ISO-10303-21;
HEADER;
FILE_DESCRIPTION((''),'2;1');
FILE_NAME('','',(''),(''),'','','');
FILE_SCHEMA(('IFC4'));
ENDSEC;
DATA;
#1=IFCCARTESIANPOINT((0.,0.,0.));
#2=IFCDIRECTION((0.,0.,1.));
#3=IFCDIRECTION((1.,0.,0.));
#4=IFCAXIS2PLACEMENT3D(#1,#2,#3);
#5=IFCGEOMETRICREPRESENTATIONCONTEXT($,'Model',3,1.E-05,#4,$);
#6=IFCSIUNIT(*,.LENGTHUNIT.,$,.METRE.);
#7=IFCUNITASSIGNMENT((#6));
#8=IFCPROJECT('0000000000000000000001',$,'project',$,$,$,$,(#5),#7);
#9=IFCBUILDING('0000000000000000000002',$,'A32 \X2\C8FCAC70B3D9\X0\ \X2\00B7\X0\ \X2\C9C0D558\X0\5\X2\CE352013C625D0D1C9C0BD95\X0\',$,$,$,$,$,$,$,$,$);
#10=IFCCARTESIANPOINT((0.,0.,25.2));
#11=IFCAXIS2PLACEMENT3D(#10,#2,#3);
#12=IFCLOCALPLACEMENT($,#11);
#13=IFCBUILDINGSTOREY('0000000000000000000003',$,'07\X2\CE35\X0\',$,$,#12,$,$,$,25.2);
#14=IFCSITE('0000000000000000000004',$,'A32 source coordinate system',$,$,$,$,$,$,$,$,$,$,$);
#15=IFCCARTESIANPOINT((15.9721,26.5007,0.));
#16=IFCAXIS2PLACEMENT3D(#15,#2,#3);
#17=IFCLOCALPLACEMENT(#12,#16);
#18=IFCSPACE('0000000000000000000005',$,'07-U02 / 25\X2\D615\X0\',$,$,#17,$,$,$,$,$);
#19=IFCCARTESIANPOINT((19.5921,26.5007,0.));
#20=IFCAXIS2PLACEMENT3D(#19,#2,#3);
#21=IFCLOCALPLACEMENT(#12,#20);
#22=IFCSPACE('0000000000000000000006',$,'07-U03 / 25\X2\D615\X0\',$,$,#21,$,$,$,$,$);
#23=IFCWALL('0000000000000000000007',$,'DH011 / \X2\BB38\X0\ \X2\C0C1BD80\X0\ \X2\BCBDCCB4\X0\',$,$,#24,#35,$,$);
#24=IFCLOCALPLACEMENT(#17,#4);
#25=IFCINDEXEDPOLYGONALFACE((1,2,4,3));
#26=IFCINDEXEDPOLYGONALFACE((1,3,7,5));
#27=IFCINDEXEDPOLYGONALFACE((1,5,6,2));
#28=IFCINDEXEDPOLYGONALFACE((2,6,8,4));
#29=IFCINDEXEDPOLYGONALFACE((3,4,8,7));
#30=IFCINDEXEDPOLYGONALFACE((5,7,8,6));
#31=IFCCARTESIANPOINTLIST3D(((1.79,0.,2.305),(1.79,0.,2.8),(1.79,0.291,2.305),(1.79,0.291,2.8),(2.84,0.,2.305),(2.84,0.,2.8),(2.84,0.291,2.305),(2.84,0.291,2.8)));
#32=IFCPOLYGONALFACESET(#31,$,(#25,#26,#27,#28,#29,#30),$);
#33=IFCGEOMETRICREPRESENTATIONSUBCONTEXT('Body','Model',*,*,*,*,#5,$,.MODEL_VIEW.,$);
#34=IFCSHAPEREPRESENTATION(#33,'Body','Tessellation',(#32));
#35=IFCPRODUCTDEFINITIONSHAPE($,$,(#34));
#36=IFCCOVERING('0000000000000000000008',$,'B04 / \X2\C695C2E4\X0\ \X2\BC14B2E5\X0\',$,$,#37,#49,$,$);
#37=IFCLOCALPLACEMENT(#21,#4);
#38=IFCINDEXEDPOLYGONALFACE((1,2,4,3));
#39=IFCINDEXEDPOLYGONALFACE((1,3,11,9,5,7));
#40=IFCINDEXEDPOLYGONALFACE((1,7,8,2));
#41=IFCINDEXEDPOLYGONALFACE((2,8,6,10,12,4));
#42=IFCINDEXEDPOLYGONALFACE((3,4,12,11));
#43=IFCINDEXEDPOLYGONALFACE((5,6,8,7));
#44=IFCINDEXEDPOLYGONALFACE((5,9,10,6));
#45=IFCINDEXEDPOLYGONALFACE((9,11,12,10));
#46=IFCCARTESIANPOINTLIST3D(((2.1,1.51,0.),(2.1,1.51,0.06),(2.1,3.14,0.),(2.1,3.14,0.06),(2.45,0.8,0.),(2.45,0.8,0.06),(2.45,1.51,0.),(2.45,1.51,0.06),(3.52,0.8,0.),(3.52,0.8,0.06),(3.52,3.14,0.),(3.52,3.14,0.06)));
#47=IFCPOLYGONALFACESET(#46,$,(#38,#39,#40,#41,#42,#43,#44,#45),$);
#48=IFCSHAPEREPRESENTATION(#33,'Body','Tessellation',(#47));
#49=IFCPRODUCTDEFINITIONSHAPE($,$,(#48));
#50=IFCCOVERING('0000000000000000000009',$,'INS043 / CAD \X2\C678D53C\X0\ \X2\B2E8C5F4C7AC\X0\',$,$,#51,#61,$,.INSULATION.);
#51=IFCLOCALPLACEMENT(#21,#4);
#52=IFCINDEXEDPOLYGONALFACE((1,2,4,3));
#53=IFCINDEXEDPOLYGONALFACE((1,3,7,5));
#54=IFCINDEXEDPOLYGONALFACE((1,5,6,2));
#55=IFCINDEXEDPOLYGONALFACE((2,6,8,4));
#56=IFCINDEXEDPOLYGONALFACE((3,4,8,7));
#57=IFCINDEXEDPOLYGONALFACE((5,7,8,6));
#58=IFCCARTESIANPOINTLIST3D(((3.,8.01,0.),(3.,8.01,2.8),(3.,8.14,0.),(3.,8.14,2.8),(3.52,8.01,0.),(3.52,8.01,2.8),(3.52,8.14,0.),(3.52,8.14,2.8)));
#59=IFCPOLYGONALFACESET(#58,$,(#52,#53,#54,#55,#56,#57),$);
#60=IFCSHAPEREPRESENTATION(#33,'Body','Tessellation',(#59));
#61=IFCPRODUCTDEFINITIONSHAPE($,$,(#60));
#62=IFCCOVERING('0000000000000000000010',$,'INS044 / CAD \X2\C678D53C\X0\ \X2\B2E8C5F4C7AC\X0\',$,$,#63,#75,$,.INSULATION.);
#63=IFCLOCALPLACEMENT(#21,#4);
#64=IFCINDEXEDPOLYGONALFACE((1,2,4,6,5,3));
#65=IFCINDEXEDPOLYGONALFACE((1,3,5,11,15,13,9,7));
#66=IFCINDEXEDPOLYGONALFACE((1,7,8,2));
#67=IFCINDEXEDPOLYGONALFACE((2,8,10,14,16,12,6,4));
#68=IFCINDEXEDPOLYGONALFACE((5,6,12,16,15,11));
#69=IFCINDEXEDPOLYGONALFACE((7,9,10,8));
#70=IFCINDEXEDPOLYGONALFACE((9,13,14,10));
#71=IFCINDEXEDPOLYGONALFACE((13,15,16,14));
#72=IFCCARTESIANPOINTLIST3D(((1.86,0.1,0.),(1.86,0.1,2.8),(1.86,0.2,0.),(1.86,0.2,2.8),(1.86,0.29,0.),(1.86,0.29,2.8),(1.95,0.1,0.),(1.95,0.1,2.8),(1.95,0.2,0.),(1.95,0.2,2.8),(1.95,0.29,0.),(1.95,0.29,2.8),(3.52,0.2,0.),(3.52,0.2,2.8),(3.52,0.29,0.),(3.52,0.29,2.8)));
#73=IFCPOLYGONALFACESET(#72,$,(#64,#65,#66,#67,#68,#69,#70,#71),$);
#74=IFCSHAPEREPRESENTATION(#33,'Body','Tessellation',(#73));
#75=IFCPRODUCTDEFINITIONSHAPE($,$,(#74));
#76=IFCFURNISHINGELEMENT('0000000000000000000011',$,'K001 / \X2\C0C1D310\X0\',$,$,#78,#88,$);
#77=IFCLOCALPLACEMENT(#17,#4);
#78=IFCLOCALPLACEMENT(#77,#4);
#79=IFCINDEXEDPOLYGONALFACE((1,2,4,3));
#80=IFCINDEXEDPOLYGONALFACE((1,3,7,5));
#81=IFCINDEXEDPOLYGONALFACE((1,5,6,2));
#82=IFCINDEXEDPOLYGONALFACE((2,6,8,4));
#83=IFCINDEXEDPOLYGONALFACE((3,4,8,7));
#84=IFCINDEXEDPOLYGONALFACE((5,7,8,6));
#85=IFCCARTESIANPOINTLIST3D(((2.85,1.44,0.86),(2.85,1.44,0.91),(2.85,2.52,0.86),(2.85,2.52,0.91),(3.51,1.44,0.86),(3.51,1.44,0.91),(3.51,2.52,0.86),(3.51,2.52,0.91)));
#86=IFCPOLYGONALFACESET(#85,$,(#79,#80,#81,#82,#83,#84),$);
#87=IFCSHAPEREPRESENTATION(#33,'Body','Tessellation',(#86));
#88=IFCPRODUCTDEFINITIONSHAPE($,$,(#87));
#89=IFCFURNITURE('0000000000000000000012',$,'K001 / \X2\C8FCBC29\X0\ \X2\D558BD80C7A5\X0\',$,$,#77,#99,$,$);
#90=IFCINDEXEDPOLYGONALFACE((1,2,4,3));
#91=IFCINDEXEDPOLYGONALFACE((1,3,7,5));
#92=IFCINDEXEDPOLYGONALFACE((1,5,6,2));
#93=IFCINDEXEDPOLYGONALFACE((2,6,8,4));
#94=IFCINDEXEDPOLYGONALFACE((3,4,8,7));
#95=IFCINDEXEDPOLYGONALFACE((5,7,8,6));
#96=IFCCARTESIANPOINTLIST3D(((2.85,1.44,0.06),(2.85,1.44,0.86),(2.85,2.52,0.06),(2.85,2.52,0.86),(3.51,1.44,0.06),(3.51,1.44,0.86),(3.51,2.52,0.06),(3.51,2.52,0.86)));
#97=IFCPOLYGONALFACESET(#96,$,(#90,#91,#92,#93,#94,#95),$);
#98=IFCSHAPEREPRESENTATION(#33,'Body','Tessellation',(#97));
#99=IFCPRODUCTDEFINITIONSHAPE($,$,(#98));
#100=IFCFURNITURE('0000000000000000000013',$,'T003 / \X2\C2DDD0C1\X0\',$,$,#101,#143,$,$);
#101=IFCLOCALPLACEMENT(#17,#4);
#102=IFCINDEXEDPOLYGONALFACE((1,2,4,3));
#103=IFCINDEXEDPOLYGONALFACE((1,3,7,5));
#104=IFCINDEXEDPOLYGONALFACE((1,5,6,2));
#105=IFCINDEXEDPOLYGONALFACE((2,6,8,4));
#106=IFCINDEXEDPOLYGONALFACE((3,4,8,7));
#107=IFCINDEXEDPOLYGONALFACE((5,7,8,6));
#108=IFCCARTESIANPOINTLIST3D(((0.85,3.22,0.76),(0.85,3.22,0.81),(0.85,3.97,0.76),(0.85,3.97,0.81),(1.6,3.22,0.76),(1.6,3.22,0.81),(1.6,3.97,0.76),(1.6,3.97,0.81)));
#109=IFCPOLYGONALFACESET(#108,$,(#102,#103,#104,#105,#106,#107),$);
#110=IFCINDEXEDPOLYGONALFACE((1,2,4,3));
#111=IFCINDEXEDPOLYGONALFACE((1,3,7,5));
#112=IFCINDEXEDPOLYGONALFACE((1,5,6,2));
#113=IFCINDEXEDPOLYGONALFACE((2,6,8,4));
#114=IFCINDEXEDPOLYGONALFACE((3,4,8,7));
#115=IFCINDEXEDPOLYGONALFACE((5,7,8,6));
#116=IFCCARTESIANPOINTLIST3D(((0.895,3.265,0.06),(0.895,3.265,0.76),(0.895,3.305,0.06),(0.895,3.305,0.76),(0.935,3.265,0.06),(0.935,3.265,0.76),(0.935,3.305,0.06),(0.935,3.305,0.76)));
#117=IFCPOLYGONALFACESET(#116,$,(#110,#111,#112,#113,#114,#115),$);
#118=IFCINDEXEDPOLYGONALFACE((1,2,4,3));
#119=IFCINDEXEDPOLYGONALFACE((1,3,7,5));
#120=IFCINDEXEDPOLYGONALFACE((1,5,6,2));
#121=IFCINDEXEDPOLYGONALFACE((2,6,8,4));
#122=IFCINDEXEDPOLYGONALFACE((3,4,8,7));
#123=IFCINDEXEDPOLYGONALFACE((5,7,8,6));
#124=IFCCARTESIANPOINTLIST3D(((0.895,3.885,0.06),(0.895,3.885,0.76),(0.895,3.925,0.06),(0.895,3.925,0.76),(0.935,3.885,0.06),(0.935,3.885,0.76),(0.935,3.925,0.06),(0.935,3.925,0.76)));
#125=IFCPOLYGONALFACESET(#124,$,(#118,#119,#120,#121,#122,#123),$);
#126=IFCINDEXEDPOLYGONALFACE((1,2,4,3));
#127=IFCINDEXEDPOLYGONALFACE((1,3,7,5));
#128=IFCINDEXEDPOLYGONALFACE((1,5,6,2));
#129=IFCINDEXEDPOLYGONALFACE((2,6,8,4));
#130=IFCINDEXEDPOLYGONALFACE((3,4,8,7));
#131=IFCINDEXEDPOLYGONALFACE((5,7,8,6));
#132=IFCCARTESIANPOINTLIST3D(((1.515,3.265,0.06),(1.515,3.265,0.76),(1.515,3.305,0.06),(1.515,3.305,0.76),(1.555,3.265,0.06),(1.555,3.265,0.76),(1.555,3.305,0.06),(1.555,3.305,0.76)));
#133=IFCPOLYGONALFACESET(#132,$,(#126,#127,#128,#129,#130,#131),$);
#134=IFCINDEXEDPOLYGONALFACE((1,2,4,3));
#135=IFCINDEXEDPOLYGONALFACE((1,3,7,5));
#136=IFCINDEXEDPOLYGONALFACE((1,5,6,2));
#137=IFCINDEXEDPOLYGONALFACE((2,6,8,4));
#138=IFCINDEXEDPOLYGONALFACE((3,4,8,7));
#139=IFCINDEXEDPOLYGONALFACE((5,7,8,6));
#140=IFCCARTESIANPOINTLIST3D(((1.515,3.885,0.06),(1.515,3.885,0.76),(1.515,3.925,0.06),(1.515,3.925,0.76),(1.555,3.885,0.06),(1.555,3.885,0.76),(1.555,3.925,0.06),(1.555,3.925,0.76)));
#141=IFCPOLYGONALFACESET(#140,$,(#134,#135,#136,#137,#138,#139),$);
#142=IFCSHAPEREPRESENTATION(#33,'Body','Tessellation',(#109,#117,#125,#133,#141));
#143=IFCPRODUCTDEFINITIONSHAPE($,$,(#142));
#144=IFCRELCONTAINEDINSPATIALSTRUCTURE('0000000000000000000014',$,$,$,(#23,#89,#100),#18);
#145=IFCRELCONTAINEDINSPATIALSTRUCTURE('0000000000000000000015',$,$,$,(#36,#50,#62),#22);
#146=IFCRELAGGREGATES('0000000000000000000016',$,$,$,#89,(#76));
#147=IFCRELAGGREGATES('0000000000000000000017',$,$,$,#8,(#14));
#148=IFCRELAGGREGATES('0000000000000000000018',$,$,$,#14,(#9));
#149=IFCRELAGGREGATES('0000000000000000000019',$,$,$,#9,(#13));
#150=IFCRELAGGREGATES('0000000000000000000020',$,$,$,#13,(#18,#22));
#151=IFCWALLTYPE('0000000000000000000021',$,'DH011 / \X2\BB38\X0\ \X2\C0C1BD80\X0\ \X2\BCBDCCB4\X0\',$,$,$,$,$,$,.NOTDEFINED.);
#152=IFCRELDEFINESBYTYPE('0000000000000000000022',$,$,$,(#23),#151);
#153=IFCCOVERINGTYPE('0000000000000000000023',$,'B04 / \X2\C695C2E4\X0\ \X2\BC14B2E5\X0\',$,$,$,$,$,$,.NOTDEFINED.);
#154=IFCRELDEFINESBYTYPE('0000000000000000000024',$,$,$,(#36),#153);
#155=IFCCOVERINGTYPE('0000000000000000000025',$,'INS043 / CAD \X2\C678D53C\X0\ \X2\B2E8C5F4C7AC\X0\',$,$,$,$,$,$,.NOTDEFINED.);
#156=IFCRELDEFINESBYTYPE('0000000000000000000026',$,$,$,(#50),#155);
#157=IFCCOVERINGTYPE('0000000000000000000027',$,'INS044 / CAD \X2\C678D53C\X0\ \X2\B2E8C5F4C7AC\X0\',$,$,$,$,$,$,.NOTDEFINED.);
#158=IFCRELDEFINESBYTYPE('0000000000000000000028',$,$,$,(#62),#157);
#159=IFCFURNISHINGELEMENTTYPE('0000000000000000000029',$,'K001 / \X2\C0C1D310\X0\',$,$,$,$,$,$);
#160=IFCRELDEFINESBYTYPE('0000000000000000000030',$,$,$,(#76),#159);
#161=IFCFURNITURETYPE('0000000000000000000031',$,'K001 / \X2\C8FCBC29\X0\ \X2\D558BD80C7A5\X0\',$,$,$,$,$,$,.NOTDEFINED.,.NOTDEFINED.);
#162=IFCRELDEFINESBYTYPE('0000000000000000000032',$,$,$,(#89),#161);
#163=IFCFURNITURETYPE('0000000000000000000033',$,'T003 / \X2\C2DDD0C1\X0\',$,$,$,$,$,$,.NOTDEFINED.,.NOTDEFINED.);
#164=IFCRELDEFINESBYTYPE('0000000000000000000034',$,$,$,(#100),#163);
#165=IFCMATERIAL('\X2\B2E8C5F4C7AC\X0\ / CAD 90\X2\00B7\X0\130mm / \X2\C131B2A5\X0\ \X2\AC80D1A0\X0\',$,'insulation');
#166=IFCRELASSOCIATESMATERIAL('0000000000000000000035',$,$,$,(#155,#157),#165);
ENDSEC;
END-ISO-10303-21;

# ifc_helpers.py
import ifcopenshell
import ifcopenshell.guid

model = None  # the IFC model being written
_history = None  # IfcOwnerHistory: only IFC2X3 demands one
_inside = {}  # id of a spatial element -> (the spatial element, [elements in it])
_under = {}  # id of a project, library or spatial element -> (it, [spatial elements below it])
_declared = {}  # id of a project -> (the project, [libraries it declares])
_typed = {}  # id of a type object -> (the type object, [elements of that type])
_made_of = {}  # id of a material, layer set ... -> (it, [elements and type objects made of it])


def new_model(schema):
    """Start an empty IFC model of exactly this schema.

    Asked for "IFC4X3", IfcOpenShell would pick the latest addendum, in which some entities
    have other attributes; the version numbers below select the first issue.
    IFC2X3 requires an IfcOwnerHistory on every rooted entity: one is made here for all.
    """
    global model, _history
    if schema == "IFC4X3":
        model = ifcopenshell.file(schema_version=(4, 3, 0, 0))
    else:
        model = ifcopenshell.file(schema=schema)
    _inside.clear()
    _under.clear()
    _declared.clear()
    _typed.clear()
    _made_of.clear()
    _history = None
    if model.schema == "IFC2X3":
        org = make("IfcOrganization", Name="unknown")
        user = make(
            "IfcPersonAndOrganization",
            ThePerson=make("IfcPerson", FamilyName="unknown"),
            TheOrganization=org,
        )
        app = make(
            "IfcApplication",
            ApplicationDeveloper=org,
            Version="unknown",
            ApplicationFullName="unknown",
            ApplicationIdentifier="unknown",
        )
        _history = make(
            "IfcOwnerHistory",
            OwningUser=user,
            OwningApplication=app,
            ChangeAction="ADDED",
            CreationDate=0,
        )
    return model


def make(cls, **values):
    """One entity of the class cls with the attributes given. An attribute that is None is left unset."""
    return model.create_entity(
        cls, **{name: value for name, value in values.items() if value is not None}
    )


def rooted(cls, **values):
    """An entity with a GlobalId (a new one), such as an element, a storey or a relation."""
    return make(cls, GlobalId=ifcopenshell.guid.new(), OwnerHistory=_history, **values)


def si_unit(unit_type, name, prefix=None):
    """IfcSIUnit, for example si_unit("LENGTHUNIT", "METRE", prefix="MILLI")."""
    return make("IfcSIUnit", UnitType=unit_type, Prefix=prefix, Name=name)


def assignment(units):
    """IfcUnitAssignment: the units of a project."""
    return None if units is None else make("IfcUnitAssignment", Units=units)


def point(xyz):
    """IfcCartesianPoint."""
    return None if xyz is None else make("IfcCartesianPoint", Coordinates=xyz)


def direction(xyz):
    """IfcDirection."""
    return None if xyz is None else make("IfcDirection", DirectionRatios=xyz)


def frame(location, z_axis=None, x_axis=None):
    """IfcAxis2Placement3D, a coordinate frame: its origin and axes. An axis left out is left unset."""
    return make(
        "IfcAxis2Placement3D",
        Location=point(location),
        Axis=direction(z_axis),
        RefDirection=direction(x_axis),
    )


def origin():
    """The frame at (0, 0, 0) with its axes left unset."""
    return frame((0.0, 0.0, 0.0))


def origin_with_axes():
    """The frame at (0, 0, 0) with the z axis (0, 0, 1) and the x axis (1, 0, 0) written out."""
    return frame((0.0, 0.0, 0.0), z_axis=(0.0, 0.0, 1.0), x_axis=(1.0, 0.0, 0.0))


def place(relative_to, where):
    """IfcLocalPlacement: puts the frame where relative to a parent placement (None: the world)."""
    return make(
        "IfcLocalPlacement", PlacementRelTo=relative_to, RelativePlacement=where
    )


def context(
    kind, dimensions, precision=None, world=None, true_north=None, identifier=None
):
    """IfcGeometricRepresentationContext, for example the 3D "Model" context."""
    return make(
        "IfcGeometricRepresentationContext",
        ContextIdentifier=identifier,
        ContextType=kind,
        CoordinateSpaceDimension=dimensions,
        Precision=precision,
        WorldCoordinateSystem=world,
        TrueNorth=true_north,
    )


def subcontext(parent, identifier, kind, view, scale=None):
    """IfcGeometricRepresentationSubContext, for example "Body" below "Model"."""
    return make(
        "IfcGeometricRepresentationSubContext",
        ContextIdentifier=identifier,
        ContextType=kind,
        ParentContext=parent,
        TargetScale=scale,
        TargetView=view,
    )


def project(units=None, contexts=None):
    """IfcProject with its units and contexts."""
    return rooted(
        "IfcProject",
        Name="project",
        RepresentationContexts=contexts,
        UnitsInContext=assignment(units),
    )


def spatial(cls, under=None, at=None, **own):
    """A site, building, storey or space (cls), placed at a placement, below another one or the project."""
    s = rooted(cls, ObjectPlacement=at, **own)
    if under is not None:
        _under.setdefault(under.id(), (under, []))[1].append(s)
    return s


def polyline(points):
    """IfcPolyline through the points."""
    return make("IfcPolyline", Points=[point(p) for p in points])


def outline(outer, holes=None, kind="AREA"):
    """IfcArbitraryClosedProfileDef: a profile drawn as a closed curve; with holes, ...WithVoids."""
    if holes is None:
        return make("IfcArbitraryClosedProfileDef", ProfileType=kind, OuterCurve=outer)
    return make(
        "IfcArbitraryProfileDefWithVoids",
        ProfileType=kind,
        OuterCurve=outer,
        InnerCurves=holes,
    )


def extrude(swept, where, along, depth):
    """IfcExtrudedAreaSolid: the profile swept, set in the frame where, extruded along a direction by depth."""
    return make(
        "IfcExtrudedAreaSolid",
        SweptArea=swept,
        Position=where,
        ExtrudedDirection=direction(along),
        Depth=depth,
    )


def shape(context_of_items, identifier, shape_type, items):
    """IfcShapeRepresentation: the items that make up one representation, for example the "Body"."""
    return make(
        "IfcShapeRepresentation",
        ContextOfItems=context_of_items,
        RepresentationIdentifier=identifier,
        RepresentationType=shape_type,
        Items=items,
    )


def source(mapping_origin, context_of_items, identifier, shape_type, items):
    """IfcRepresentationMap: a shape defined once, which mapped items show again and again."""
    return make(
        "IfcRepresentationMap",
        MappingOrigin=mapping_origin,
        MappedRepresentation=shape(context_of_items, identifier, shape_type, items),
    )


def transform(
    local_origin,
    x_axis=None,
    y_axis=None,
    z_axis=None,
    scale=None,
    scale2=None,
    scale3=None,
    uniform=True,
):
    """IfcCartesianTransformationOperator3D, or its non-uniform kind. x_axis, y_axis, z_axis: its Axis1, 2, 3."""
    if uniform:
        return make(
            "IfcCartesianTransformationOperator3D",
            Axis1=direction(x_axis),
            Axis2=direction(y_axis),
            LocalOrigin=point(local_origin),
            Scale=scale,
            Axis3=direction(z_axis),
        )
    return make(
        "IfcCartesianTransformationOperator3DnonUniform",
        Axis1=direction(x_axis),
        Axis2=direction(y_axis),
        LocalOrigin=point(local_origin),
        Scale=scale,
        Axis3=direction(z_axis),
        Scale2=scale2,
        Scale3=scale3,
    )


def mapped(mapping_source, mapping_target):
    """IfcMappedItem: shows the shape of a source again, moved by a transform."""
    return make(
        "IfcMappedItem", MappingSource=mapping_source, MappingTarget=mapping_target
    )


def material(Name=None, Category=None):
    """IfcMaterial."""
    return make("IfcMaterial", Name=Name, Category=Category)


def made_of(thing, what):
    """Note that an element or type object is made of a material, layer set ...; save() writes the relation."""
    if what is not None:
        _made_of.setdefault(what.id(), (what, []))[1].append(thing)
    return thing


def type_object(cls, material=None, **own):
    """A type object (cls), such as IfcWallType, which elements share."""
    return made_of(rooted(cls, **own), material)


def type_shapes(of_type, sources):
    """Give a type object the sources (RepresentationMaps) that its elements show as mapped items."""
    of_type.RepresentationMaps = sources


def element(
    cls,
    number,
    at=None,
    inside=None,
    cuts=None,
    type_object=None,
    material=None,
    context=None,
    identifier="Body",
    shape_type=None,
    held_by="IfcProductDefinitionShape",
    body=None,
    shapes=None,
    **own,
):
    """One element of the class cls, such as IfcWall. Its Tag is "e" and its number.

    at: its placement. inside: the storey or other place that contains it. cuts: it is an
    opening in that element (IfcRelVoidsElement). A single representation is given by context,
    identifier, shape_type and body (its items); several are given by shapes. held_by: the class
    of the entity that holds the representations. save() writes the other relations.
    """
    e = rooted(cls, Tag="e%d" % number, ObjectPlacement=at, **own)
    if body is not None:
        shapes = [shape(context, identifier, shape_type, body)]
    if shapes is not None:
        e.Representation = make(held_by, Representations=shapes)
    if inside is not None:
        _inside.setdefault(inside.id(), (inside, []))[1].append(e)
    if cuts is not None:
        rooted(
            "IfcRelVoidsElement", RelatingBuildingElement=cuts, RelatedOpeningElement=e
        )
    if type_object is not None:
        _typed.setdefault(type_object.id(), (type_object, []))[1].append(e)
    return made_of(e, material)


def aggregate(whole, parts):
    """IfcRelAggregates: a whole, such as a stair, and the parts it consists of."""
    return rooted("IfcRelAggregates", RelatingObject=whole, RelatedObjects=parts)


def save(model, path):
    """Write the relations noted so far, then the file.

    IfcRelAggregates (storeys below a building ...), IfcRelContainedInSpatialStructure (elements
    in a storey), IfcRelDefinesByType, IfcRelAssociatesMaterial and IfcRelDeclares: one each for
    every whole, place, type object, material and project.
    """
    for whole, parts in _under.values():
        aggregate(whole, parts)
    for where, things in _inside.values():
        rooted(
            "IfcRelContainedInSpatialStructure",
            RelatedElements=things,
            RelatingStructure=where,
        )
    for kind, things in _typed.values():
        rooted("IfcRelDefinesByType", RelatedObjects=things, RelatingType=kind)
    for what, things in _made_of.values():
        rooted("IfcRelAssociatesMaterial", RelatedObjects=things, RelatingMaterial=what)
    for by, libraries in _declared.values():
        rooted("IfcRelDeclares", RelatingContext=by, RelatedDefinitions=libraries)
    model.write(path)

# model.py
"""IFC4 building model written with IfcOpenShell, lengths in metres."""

from ifc_helpers import new_model, si_unit, frame, origin, origin_with_axes, place, context, subcontext, project, spatial, polyline, outline, extrude, source, transform, mapped, material, type_object, type_shapes, element, aggregate, save


model = new_model("IFC4")

# Units and contexts
model_context = context("Model", 3, precision=1e-05, world=origin_with_axes())
body_context = subcontext(model_context, "Body", "Model", "MODEL_VIEW")
ifc_project = project(units=[si_unit("LENGTHUNIT", "METRE")], contexts=[model_context])

# Site, building, storey, space
site = spatial("IfcSite", under=ifc_project, Name="A32 source coordinate system")
building = spatial("IfcBuilding", under=site, Name="A32 주거동 · 지하5층–옥탑지붕")
storey_placement = place(None, frame((0.0, 0.0, 25.2), z_axis=(0.0, 0.0, 1.0), x_axis=(1.0, 0.0, 0.0)))
storey = spatial("IfcBuildingStorey", under=building, at=storey_placement, Name="07층", Elevation=25.2)
space_1_placement = place(storey_placement, frame((15.9721, 26.5007, 0.0), z_axis=(0.0, 0.0, 1.0), x_axis=(1.0, 0.0, 0.0)))
space_1 = spatial("IfcSpace", under=storey, at=space_1_placement, Name="07-U02 / 25형")

# Wall
wall_type_1 = type_object("IfcWallType", Name="DH011 / 문 상부 벽체", PredefinedType="NOTDEFINED")
shared_shape_1 = source(origin(), body_context, "Body", "SweptSolid", [
    extrude(outline(polyline([(2.84, 0.0), (1.79, 0.0), (1.79, 0.291), (2.84, 0.291), (2.84, 0.0)])), frame((0.0, 0.0, 2.305)), (0.0, 0.0, 1.0), 0.495),
])
type_shapes(wall_type_1, [shared_shape_1])
wall_1_placement = place(space_1_placement, origin_with_axes())
element("IfcWall", 1, at=wall_1_placement, inside=space_1, type_object=wall_type_1, Name="DH011 / 문 상부 벽체", context=body_context, shape_type="MappedRepresentation", body=[
    mapped(shared_shape_1, transform((0.0, 0.0, 0.0), scale=1.0)),
])

# Shared definitions
space_2_placement = place(storey_placement, frame((19.5921, 26.5007, 0.0), z_axis=(0.0, 0.0, 1.0), x_axis=(1.0, 0.0, 0.0)))
space_2 = spatial("IfcSpace", under=storey, at=space_2_placement, Name="07-U03 / 25형")

# Coverings
covering_type_1 = type_object("IfcCoveringType", Name="B04 / 욕실 바닥", PredefinedType="NOTDEFINED")
shared_shape_2 = source(origin(), body_context, "Body", "SweptSolid", [
    extrude(outline(polyline([(2.1, 1.51), (2.1, 3.14), (3.52, 3.14), (3.52, 0.8), (2.45, 0.8), (2.45, 1.51), (2.1, 1.51)])), origin(), (0.0, 0.0, 1.0), 0.06),
])
type_shapes(covering_type_1, [shared_shape_2])
covering_1_placement = place(space_2_placement, origin_with_axes())
element("IfcCovering", 2, at=covering_1_placement, inside=space_2, type_object=covering_type_1, Name="B04 / 욕실 바닥", context=body_context, shape_type="MappedRepresentation", body=[
    mapped(shared_shape_2, transform((0.0, 0.0, 0.0), scale=1.0)),
])
ifc_material = material(Name="단열재 / CAD 90·130mm / 성능 검토", Category="insulation")
covering_type_2 = type_object("IfcCoveringType", Name="INS043 / CAD 외피 단열재", PredefinedType="NOTDEFINED", material=ifc_material)
shared_shape_3 = source(origin(), body_context, "Body", "SweptSolid", [
    extrude(outline(polyline([(3.52, 8.14), (3.52, 8.01), (3.0, 8.01), (3.0, 8.14), (3.52, 8.14)])), origin(), (0.0, 0.0, 1.0), 2.8),
])
type_shapes(covering_type_2, [shared_shape_3])
covering_2_placement = place(space_2_placement, origin_with_axes())
element("IfcCovering", 3, at=covering_2_placement, inside=space_2, type_object=covering_type_2, Name="INS043 / CAD 외피 단열재", PredefinedType="INSULATION", context=body_context, shape_type="MappedRepresentation", body=[
    mapped(shared_shape_3, transform((0.0, 0.0, 0.0), scale=1.0)),
])
covering_type_3 = type_object("IfcCoveringType", Name="INS044 / CAD 외피 단열재", PredefinedType="NOTDEFINED", material=ifc_material)
shared_shape_4 = source(origin(), body_context, "Body", "SweptSolid", [
    extrude(outline(polyline([(1.86, 0.2), (1.86, 0.29), (1.95, 0.29), (3.52, 0.29), (3.52, 0.2), (1.95, 0.2), (1.95, 0.1), (1.86, 0.1), (1.86, 0.2)])), origin(), (0.0, 0.0, 1.0), 2.8),
])
type_shapes(covering_type_3, [shared_shape_4])
covering_3_placement = place(space_2_placement, origin_with_axes())
element("IfcCovering", 4, at=covering_3_placement, inside=space_2, type_object=covering_type_3, Name="INS044 / CAD 외피 단열재", PredefinedType="INSULATION", context=body_context, shape_type="MappedRepresentation", body=[
    mapped(shared_shape_4, transform((0.0, 0.0, 0.0), scale=1.0)),
])

# Furnishing element
furnishing_element_type_1 = type_object("IfcFurnishingElementType", Name="K001 / 상판")
shared_shape_5 = source(origin(), body_context, "Body", "SweptSolid", [
    extrude(outline(polyline([(2.85, 2.52), (3.51, 2.52), (3.51, 1.44), (2.85, 1.44), (2.85, 2.52)])), frame((0.0, 0.0, 0.86)), (0.0, 0.0, 1.0), 0.05),
])
type_shapes(furnishing_element_type_1, [shared_shape_5])
furniture_1_placement = place(space_1_placement, origin_with_axes())
furnishing_1_placement = place(furniture_1_placement, origin_with_axes())
furnishing_1 = element("IfcFurnishingElement", 5, at=furnishing_1_placement, type_object=furnishing_element_type_1, Name="K001 / 상판", context=body_context, shape_type="MappedRepresentation", body=[
    mapped(shared_shape_5, transform((0.0, 0.0, 0.0), scale=1.0)),
])

# Furniture
furniture_type_1 = type_object("IfcFurnitureType", Name="K001 / 주방 하부장", AssemblyPlace="NOTDEFINED", PredefinedType="NOTDEFINED")
shared_shape_6 = source(origin(), body_context, "Body", "SweptSolid", [
    extrude(outline(polyline([(2.85, 1.44), (2.85, 2.52), (3.51, 2.52), (3.51, 1.44), (2.85, 1.44)])), frame((0.0, 0.0, 0.06)), (0.0, 0.0, 1.0), 0.8),
])
type_shapes(furniture_type_1, [shared_shape_6])
furniture_1 = element("IfcFurniture", 6, at=furniture_1_placement, inside=space_1, type_object=furniture_type_1, Name="K001 / 주방 하부장", context=body_context, shape_type="MappedRepresentation", body=[
    mapped(shared_shape_6, transform((0.0, 0.0, 0.0), scale=1.0)),
])
aggregate(furniture_1, [furnishing_1])
furniture_type_2 = type_object("IfcFurnitureType", Name="T003 / 식탁", AssemblyPlace="NOTDEFINED", PredefinedType="NOTDEFINED")
shared_shape_7 = source(origin(), body_context, "Body", "SweptSolid", [
    extrude(outline(polyline([(1.6, 3.97), (1.6, 3.22), (0.85, 3.22), (0.85, 3.97), (1.6, 3.97)])), frame((0.0, 0.0, 0.76)), (0.0, 0.0, 1.0), 0.05),
    extrude(outline(polyline([(0.895, 3.265), (0.895, 3.305), (0.935, 3.305), (0.935, 3.265), (0.895, 3.265)])), frame((0.0, 0.0, 0.06)), (0.0, 0.0, 1.0), 0.7),
    extrude(outline(polyline([(0.895, 3.885), (0.895, 3.925), (0.935, 3.925), (0.935, 3.885), (0.895, 3.885)])), frame((0.0, 0.0, 0.06)), (0.0, 0.0, 1.0), 0.7),
    extrude(outline(polyline([(1.515, 3.265), (1.515, 3.305), (1.555, 3.305), (1.555, 3.265), (1.515, 3.265)])), frame((0.0, 0.0, 0.06)), (0.0, 0.0, 1.0), 0.7),
    extrude(outline(polyline([(1.515, 3.885), (1.515, 3.925), (1.555, 3.925), (1.555, 3.885), (1.515, 3.885)])), frame((0.0, 0.0, 0.06)), (0.0, 0.0, 1.0), 0.7),
])
type_shapes(furniture_type_2, [shared_shape_7])
furniture_2_placement = place(space_1_placement, origin_with_axes())
element("IfcFurniture", 7, at=furniture_2_placement, inside=space_1, type_object=furniture_type_2, Name="T003 / 식탁", context=body_context, shape_type="MappedRepresentation", body=[
    mapped(shared_shape_7, transform((0.0, 0.0, 0.0), scale=1.0)),
])

save(model, "model.ifc")
